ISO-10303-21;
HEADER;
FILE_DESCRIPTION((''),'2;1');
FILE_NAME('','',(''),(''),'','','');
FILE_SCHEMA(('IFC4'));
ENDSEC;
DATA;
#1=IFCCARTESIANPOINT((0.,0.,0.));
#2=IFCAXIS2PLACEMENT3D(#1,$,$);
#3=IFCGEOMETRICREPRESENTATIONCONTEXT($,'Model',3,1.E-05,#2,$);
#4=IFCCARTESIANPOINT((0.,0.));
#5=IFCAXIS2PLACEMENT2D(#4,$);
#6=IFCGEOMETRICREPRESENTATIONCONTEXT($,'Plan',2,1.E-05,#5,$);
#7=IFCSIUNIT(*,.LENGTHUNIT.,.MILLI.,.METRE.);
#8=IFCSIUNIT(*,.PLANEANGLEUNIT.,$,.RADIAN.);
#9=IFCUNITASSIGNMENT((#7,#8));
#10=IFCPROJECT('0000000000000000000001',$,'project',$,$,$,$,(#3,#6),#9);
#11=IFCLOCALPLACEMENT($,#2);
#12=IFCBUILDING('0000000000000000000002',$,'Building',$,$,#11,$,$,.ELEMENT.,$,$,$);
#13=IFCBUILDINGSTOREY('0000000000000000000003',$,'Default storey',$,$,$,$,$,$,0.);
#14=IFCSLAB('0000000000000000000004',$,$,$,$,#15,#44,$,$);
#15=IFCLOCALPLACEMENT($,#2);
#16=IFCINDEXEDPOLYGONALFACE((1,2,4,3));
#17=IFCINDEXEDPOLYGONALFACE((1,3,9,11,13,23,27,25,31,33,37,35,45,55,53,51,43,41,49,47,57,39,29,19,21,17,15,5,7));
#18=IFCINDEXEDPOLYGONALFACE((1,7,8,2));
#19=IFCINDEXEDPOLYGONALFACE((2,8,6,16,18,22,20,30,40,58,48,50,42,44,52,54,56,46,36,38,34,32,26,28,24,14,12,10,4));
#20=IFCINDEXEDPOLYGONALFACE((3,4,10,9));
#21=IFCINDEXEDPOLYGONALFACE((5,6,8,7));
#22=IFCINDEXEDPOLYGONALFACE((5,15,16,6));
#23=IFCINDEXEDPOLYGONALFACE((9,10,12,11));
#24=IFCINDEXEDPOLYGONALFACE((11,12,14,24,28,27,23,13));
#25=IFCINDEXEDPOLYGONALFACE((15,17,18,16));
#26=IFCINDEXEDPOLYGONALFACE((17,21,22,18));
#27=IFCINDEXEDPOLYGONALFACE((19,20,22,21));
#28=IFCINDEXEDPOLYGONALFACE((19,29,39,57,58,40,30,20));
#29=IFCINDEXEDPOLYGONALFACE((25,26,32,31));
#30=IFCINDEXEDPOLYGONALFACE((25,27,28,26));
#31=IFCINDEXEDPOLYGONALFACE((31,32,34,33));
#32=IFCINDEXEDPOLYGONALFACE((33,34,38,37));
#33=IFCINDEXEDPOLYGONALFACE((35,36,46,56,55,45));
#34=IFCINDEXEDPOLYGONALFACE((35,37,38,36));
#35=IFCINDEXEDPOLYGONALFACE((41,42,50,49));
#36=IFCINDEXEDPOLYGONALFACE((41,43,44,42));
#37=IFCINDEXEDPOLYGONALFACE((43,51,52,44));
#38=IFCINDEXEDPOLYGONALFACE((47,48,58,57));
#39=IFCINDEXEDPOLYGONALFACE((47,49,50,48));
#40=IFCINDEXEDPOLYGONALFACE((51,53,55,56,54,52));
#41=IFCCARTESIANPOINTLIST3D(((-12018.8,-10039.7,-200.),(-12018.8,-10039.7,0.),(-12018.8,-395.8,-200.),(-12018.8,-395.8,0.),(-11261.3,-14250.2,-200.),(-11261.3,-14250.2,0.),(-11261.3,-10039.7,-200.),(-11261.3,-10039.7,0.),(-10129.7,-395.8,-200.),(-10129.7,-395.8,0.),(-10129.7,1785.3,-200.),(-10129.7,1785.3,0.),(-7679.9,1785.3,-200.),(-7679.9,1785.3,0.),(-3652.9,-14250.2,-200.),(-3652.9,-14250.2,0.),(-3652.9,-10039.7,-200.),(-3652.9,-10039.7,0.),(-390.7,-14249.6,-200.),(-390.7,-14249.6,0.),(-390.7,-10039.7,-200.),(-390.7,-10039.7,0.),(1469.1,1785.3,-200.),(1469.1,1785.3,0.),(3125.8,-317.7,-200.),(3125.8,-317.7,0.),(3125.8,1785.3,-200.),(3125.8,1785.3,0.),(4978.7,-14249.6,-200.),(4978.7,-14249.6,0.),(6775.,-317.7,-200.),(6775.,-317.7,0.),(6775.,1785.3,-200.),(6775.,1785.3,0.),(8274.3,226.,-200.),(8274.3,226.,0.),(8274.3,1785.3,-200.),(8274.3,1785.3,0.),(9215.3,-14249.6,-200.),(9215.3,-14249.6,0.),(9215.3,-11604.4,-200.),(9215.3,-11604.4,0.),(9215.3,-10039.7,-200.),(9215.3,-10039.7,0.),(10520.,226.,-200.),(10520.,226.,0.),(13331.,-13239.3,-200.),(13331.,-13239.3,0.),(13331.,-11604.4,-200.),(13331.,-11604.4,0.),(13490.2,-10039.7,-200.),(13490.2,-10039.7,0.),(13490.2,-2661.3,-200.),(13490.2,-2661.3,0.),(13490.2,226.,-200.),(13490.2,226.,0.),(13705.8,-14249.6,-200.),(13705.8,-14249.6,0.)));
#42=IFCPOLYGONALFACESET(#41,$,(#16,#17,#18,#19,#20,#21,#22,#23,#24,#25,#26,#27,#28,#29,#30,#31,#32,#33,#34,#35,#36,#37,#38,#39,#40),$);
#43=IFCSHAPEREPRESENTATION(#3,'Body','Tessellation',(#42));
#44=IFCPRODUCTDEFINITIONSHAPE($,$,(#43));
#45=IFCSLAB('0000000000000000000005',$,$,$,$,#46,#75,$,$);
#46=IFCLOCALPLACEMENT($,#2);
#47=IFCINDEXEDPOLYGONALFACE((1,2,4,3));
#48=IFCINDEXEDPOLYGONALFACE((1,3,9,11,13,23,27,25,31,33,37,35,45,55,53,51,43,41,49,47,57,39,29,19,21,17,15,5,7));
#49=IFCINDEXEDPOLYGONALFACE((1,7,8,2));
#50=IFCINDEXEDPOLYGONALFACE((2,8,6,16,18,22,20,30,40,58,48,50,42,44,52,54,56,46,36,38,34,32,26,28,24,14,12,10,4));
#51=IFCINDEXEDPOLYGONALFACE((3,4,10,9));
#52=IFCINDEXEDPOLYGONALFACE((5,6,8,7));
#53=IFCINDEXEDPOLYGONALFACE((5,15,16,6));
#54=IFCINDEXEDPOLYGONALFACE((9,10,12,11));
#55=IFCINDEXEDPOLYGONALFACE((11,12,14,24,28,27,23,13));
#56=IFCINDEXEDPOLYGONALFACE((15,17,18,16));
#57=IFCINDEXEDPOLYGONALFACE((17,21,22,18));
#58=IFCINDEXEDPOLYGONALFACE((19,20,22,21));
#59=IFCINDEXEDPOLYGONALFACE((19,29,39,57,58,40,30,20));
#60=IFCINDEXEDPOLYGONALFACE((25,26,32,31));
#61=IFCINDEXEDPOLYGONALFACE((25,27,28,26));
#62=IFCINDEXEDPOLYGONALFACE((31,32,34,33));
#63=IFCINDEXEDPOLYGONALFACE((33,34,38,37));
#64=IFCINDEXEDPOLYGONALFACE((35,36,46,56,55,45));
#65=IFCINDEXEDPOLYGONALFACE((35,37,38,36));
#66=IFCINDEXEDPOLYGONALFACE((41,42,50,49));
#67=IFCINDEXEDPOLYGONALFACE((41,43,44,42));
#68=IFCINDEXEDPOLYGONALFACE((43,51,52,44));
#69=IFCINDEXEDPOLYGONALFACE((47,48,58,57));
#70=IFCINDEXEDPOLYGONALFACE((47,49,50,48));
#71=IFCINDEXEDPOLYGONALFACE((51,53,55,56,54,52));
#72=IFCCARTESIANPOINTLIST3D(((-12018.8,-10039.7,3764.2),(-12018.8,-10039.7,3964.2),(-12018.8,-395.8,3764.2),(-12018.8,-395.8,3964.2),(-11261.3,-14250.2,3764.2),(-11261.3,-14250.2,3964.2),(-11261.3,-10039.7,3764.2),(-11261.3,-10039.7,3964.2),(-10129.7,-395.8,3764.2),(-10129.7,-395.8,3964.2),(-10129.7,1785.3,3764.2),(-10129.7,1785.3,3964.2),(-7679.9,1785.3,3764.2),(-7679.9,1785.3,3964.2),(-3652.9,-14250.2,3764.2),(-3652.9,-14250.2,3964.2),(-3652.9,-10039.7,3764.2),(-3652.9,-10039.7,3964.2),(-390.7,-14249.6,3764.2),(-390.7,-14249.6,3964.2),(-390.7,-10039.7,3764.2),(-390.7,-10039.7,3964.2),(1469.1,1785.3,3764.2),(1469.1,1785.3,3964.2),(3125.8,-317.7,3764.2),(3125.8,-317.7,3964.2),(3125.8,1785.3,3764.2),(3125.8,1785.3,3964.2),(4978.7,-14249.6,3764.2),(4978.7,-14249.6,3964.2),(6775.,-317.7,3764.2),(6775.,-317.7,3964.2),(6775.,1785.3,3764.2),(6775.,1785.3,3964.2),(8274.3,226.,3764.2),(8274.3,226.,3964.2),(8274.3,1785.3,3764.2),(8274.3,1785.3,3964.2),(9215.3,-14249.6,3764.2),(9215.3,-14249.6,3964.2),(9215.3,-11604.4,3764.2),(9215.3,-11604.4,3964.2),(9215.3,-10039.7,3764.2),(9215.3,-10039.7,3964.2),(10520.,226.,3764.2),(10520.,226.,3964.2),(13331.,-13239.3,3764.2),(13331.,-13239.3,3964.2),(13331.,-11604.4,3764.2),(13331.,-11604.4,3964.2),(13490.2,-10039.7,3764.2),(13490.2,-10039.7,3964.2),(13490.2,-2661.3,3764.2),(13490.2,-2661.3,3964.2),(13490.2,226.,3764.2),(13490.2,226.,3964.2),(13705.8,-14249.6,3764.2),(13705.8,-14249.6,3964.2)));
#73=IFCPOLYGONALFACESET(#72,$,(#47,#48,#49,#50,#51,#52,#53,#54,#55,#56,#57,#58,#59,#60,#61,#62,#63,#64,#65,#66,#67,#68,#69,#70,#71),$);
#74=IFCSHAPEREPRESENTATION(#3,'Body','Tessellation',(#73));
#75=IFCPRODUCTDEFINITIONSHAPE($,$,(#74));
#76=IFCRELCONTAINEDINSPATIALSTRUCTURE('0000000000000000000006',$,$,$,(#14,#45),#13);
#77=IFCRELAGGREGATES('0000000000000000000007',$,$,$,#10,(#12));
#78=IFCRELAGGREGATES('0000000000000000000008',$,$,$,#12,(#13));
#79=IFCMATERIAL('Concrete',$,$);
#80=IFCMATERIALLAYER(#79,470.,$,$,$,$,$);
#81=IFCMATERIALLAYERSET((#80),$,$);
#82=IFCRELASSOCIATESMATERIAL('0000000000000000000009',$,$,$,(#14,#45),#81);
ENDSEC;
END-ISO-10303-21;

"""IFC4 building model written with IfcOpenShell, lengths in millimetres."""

from ifc_helpers import new_model, si_unit, frame, origin, origin_2d, place, context, project, spatial, polyline, outline, extrude, material, layer, layer_set, layer_usage, element, save


model = new_model("IFC4")

# Units and contexts
model_context = context("Model", 3, precision=1e-05, world=origin())
plan_context = context("Plan", 2, precision=1e-05, world=origin_2d())
ifc_project = project(units=[si_unit("LENGTHUNIT", "METRE", prefix="MILLI"), si_unit("PLANEANGLEUNIT", "RADIAN")], contexts=[model_context, plan_context])

# Building, storey
placement = place(None, origin())
building = spatial("IfcBuilding", under=ifc_project, at=placement, Name="Building", CompositionType="ELEMENT")
storey = spatial("IfcBuildingStorey", under=building, Name="Default storey", Elevation=0.0)

# Slabs
ifc_material_1 = material(Name="Concrete")
ifc_layer_1 = layer(ifc_material_1, 470.0)
ifc_layer_set_1 = layer_set([ifc_layer_1])
ifc_layer_usage_1 = layer_usage(ifc_layer_set_1, "AXIS3", "POSITIVE", 0.0)
element("IfcSlab", 1, at=placement, inside=storey, material=ifc_layer_usage_1, context=model_context, shape_type="SweptSolid", body=[
    extrude(outline(polyline([(13331.0, -13239.3), (13331.0, -11604.4), (9215.3, -11604.4), (9215.3, -10039.7), (13490.2, -10039.7), (13490.2, -2661.3), (13490.2, 226.0), (10520.0, 226.0), (8274.3, 226.0), (8274.3, 1785.3), (6775.0, 1785.3), (6775.0, -317.7), (3125.8, -317.7), (3125.8, 1785.3), (1469.1, 1785.3), (-7679.9, 1785.3), (-10129.7, 1785.3), (-10129.7, -395.8), (-12018.8, -395.8), (-12018.8, -10039.7), (-11261.3, -10039.7), (-11261.3, -14250.2), (-3652.9, -14250.2), (-3652.9, -10039.7), (-390.7, -10039.7), (-390.7, -14249.6), (4978.7, -14249.6), (9215.3, -14249.6), (13705.8, -14249.6), (13331.0, -13239.3)])), frame((0.0, 0.0, -200.0), z_axis=(0.0, 0.0, 1000.0), x_axis=(1000.0, 0.0, 0.0)), (0.0, 0.0, 1.0), 200.0),
])
element("IfcSlab", 2, at=placement, inside=storey, material=ifc_layer_usage_1, context=model_context, shape_type="SweptSolid", body=[
    extrude(outline(polyline([(13331.0, -13239.3), (13331.0, -11604.4), (9215.3, -11604.4), (9215.3, -10039.7), (13490.2, -10039.7), (13490.2, -2661.3), (13490.2, 226.0), (10520.0, 226.0), (8274.3, 226.0), (8274.3, 1785.3), (6775.0, 1785.3), (6775.0, -317.7), (3125.8, -317.7), (3125.8, 1785.3), (1469.1, 1785.3), (-7679.9, 1785.3), (-10129.7, 1785.3), (-10129.7, -395.8), (-12018.8, -395.8), (-12018.8, -10039.7), (-11261.3, -10039.7), (-11261.3, -14250.2), (-3652.9, -14250.2), (-3652.9, -10039.7), (-390.7, -10039.7), (-390.7, -14249.6), (4978.7, -14249.6), (9215.3, -14249.6), (13705.8, -14249.6), (13331.0, -13239.3)])), frame((0.0, 0.0, 3964.2), z_axis=(0.0, 0.0, 1000.0), x_axis=(1000.0, 0.0, 0.0)), (0.0, 0.0, -1.0), 200.0),
])

save(model, "model.ifc")
